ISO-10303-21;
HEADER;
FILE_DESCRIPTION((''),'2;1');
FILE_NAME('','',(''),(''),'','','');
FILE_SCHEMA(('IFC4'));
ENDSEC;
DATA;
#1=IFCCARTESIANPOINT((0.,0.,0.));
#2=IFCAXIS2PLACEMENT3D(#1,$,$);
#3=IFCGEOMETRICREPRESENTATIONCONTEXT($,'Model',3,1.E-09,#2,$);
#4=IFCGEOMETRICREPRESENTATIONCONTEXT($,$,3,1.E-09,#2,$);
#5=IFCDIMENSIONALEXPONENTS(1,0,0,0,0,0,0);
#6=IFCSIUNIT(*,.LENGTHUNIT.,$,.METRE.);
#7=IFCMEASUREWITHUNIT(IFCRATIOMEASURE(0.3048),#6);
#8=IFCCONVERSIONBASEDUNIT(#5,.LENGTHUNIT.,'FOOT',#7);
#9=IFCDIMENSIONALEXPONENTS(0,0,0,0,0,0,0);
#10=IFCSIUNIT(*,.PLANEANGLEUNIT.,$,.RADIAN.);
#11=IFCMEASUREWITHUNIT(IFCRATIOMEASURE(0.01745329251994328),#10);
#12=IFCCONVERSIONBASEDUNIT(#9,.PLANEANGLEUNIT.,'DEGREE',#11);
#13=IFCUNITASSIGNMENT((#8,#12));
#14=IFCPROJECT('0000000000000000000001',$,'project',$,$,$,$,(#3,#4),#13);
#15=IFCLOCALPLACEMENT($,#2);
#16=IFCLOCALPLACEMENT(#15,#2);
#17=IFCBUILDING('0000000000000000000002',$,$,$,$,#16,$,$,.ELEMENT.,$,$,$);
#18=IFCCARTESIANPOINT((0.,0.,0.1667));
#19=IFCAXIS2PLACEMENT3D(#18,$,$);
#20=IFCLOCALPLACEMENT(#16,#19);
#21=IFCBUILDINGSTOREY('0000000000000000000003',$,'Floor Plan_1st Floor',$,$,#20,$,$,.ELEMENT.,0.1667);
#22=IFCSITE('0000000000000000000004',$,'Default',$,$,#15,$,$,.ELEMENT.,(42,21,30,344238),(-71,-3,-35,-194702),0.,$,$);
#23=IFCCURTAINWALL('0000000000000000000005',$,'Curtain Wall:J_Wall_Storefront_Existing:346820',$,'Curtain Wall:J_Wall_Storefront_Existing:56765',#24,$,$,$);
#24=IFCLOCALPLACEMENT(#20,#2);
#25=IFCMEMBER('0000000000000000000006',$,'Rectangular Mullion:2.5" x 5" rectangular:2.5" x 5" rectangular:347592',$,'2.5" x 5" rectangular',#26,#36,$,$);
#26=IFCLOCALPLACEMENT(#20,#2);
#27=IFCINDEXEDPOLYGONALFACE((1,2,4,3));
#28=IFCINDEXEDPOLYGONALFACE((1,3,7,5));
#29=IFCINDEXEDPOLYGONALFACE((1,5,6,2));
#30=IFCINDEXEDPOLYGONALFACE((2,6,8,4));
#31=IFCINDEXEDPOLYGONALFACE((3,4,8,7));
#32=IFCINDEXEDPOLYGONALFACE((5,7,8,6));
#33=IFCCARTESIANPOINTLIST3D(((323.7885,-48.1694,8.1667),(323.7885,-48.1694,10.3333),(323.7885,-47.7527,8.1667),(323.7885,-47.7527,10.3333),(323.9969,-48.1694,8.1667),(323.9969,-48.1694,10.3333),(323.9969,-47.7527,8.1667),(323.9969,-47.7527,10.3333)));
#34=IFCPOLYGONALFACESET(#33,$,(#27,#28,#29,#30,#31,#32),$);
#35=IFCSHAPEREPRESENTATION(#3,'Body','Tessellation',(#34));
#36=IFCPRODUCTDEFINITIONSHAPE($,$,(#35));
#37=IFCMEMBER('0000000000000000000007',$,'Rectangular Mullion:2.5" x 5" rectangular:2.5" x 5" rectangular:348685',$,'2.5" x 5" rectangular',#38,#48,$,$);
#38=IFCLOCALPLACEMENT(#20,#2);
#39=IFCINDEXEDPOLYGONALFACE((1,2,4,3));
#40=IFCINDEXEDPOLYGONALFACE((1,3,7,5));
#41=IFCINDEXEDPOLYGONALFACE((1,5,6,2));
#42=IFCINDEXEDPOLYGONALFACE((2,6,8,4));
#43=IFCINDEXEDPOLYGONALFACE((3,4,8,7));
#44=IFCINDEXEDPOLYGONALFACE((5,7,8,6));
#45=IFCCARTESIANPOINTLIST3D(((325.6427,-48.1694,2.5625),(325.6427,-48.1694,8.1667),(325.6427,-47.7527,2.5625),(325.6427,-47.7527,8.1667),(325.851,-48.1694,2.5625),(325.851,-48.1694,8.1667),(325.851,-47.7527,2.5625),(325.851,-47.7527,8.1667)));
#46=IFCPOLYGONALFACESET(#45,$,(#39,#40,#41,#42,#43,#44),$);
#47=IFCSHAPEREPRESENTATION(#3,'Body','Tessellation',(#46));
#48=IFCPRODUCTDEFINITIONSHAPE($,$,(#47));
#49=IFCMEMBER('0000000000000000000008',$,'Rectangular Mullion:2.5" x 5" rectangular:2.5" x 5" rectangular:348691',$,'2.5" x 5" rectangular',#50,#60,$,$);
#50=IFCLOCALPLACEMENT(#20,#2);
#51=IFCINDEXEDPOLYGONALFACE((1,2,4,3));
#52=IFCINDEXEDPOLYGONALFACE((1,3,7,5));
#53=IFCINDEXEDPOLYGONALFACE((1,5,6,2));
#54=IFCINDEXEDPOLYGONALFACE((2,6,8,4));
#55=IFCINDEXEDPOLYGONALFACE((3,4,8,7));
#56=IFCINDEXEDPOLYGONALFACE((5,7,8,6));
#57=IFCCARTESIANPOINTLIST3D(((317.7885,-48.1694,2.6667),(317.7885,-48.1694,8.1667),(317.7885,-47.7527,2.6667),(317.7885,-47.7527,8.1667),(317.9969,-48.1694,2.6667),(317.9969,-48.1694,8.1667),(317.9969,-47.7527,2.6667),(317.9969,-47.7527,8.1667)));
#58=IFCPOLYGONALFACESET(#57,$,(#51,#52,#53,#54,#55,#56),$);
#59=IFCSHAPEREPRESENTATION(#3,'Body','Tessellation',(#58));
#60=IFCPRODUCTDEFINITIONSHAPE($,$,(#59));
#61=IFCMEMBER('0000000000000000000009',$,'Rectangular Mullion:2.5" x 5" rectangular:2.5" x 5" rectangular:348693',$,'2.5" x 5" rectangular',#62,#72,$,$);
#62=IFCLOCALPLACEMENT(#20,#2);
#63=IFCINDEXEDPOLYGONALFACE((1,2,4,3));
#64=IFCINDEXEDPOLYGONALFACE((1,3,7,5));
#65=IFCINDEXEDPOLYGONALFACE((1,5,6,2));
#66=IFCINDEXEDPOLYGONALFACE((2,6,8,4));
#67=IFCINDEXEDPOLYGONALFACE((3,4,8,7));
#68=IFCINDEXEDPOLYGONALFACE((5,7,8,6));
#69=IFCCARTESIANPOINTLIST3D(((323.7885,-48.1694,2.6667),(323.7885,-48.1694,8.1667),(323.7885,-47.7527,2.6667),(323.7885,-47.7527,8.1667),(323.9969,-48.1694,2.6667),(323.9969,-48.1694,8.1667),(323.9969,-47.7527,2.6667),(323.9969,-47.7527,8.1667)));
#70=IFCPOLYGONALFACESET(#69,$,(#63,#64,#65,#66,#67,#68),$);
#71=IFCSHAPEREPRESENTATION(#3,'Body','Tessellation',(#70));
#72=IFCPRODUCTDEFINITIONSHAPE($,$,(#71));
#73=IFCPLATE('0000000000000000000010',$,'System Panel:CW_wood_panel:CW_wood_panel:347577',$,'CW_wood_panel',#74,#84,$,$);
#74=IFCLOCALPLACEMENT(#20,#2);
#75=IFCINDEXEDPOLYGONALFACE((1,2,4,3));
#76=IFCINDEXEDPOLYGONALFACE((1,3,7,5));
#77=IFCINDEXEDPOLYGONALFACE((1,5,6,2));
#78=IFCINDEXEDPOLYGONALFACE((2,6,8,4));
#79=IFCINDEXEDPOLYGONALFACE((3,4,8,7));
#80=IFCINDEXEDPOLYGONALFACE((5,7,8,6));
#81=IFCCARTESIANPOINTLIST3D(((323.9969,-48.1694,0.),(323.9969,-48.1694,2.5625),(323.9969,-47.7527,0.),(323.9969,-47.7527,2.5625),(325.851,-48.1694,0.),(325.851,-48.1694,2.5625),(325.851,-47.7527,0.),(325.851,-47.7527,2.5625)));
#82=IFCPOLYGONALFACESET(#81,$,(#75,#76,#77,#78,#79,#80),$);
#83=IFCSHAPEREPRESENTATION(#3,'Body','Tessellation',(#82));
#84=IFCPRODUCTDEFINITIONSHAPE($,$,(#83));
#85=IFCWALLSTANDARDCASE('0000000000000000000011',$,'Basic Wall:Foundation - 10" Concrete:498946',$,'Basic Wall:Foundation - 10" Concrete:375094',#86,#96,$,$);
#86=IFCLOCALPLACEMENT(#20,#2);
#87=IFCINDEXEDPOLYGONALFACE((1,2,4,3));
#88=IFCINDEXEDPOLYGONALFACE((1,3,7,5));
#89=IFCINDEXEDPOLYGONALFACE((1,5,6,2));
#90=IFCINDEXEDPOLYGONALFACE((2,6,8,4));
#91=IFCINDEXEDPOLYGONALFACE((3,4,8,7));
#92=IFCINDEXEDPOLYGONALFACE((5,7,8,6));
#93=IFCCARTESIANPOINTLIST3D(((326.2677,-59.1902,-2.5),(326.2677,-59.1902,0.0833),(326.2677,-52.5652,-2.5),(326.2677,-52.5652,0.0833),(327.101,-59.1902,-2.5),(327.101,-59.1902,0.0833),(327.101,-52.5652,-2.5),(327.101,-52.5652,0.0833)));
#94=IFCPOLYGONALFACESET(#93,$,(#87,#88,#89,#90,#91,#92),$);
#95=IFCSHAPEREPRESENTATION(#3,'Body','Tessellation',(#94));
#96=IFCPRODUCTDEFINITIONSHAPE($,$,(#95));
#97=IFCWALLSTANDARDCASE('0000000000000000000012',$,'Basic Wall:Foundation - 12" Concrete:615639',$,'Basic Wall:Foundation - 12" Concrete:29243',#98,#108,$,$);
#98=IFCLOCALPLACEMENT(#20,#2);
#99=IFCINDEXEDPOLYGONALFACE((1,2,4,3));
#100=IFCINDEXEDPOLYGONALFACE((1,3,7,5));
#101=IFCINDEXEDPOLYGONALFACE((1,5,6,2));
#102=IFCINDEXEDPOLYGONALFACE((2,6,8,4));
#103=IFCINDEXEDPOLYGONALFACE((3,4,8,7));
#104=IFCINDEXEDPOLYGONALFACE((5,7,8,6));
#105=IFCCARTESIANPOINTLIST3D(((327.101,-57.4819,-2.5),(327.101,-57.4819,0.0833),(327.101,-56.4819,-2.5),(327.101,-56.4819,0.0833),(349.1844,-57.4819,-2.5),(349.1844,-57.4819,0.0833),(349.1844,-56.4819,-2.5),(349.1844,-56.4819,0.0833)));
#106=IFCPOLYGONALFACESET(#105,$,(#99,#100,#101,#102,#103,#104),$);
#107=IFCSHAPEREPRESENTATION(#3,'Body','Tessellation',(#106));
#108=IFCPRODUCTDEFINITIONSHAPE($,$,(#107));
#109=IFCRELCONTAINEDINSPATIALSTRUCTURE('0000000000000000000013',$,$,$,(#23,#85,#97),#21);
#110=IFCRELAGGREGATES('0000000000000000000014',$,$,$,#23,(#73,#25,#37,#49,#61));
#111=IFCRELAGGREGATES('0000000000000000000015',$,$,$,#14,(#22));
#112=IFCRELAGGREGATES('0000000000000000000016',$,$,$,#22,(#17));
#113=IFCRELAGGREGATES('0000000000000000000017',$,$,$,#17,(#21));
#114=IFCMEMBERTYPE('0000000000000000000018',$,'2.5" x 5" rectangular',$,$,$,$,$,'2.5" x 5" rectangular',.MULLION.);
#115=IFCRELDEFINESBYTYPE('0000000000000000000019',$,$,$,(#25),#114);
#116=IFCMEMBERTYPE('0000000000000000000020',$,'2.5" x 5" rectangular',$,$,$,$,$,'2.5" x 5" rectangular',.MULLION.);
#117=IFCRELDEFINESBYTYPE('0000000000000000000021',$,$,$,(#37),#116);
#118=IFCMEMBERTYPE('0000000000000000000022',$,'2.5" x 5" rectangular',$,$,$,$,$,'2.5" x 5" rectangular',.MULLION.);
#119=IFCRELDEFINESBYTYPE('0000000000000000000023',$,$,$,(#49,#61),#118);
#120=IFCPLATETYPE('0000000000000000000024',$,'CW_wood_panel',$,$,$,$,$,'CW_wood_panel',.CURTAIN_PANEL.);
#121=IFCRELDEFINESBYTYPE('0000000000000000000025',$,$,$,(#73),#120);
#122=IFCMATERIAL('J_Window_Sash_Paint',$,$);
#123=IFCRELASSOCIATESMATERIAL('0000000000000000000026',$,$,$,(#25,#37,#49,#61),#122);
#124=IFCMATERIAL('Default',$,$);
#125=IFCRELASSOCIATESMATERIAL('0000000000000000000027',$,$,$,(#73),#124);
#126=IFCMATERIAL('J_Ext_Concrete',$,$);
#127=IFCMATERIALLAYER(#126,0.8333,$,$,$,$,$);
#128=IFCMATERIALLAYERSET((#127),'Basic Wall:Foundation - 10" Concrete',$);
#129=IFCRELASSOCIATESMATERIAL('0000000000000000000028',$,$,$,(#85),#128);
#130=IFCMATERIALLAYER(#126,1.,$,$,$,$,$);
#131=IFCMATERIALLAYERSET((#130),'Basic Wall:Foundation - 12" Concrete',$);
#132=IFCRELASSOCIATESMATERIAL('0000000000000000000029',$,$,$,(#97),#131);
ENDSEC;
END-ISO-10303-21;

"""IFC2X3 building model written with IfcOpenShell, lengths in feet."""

from ifc_helpers import new_model, entity, si_unit, converted_unit, frame, frame_2d, origin, origin_2d_with_axis, place, context, project, spatial, rectangle, extrude, source, transform, mapped, material, layer, layer_set, layer_usage, type_object, type_shapes, element, aggregate, save


model = new_model("IFC2X3")

# Units and contexts
model_context = context("Model", 3, precision=1e-09, world=origin())
context_of_model = context(None, 3, precision=1e-09, world=origin())
ifc_project = project(units=[converted_unit("LENGTHUNIT", "FOOT", entity("IfcRatioMeasure", 0.3048), si_unit("LENGTHUNIT", "METRE"), dimensions=[1, 0, 0, 0, 0, 0, 0]), converted_unit("PLANEANGLEUNIT", "DEGREE", entity("IfcRatioMeasure", 0.01745329251994328), si_unit("PLANEANGLEUNIT", "RADIAN"), dimensions=[0, 0, 0, 0, 0, 0, 0])], contexts=[model_context, context_of_model])

# Site, building, storey
site_placement = place(None, origin())
site = spatial("IfcSite", under=ifc_project, at=site_placement, Name="Default", CompositionType="ELEMENT", RefLatitude=(42, 21, 30, 344238), RefLongitude=(-71, -3, -35, -194702), RefElevation=0.0)
building_placement = place(site_placement, origin())
building = spatial("IfcBuilding", under=site, at=building_placement, CompositionType="ELEMENT")
storey_placement = place(building_placement, frame((0.0, 0.0, 0.1667)))
storey = spatial("IfcBuildingStorey", under=building, at=storey_placement, Name="Floor Plan_1st Floor", CompositionType="ELEMENT", Elevation=0.1667)

# Curtain wall, members, plate
curtain_wall_placement = place(storey_placement, origin())
curtain_wall = element("IfcCurtainWall", 1, at=curtain_wall_placement, inside=storey, Name="Curtain Wall:J_Wall_Storefront_Existing:346820", ObjectType="Curtain Wall:J_Wall_Storefront_Existing:56765")
ifc_material_1 = material(Name="J_Window_Sash_Paint")
member_type_1 = type_object("IfcMemberType", Name="2.5\" x 5\" rectangular", ElementType="2.5\" x 5\" rectangular", PredefinedType="MULLION")
shared_shape_1 = source(origin(), model_context, "Body", "SweptSolid", [
    extrude(rectangle(XDim=0.2083, YDim=0.4167, at=origin_2d_with_axis()), frame((0.0, 0.0, -2.1667), z_axis=(0.0, 0.0, 1.0), x_axis=(-1.0, 0.0, 0.0)), (0.0, 0.0, 1.0), 2.1667),
])
type_shapes(member_type_1, [shared_shape_1])
member_1_placement = place(storey_placement, frame((323.8927, -47.9611, 8.1667), z_axis=(0.0, 0.0, -1.0), x_axis=(1.0, 0.0, 0.0)))
member_1 = element("IfcMember", 2, at=member_1_placement, type_object=member_type_1, material=ifc_material_1, Name="Rectangular Mullion:2.5\" x 5\" rectangular:2.5\" x 5\" rectangular:347592", ObjectType="2.5\" x 5\" rectangular", context=model_context, shape_type="MappedRepresentation", body=[
    mapped(shared_shape_1, transform((0.0, 0.0, 0.0), scale=1.0)),
])
member_type_2 = type_object("IfcMemberType", Name="2.5\" x 5\" rectangular", ElementType="2.5\" x 5\" rectangular", PredefinedType="MULLION")
shared_shape_2 = source(origin(), model_context, "Body", "SweptSolid", [
    extrude(rectangle(XDim=0.2083, YDim=0.4167, at=origin_2d_with_axis()), frame((-0.1042, 0.0, -5.6042), z_axis=(0.0, 0.0, 1.0), x_axis=(-1.0, 0.0, 0.0)), (0.0, 0.0, 1.0), 5.6042),
])
type_shapes(member_type_2, [shared_shape_2])
member_2_placement = place(storey_placement, frame((325.851, -47.9611, 2.5625), z_axis=(0.0, 0.0, -1.0), x_axis=(1.0, 0.0, 0.0)))
member_2 = element("IfcMember", 3, at=member_2_placement, type_object=member_type_2, material=ifc_material_1, Name="Rectangular Mullion:2.5\" x 5\" rectangular:2.5\" x 5\" rectangular:348685", ObjectType="2.5\" x 5\" rectangular", context=model_context, shape_type="MappedRepresentation", body=[
    mapped(shared_shape_2, transform((0.0, 0.0, 0.0), scale=1.0)),
])
member_type_3 = type_object("IfcMemberType", Name="2.5\" x 5\" rectangular", ElementType="2.5\" x 5\" rectangular", PredefinedType="MULLION")
shared_shape_3 = source(origin(), model_context, "Body", "SweptSolid", [
    extrude(rectangle(XDim=0.2083, YDim=0.4167, at=origin_2d_with_axis()), frame((0.0, 0.0, -5.5), z_axis=(0.0, 0.0, 1.0), x_axis=(-1.0, 0.0, 0.0)), (0.0, 0.0, 1.0), 5.5),
])
type_shapes(member_type_3, [shared_shape_3])
member_3_placement = place(storey_placement, frame((317.8927, -47.9611, 2.6667), z_axis=(0.0, 0.0, -1.0), x_axis=(1.0, 0.0, 0.0)))
member_3 = element("IfcMember", 4, at=member_3_placement, type_object=member_type_3, material=ifc_material_1, Name="Rectangular Mullion:2.5\" x 5\" rectangular:2.5\" x 5\" rectangular:348691", ObjectType="2.5\" x 5\" rectangular", context=model_context, shape_type="MappedRepresentation", body=[
    mapped(shared_shape_3, transform((0.0, 0.0, 0.0), scale=1.0)),
])
member_4_placement = place(storey_placement, frame((323.8927, -47.9611, 2.6667), z_axis=(0.0, 0.0, -1.0), x_axis=(1.0, 0.0, 0.0)))
member_4 = element("IfcMember", 5, at=member_4_placement, type_object=member_type_3, material=ifc_material_1, Name="Rectangular Mullion:2.5\" x 5\" rectangular:2.5\" x 5\" rectangular:348693", ObjectType="2.5\" x 5\" rectangular", context=model_context, shape_type="MappedRepresentation", body=[
    mapped(shared_shape_3, transform((0.0, 0.0, 0.0), scale=1.0)),
])
ifc_material_2 = material(Name="Default")
plate_type_1 = type_object("IfcPlateType", Name="CW_wood_panel", ElementType="CW_wood_panel", PredefinedType="CURTAIN_PANEL")
shared_shape_4 = source(origin(), model_context, "Body", "SweptSolid", [
    extrude(rectangle(XDim=0.4167, YDim=1.8542, at=origin_2d_with_axis()), frame((0.0, 0.0, 0.0), z_axis=(0.0, 0.0, 1.0), x_axis=(0.0, 1.0, 0.0)), (0.0, 0.0, 1.0), 2.5625),
])
type_shapes(plate_type_1, [shared_shape_4])
plate_1_placement = place(storey_placement, frame((324.9239, -47.9611, 0.0)))
plate_1 = element("IfcPlate", 6, at=plate_1_placement, type_object=plate_type_1, material=ifc_material_2, Name="System Panel:CW_wood_panel:CW_wood_panel:347577", ObjectType="CW_wood_panel", context=model_context, shape_type="MappedRepresentation", body=[
    mapped(shared_shape_4, transform((0.0, 0.0, 0.0), scale=1.0)),
])
aggregate(curtain_wall, [plate_1, member_1, member_2, member_3, member_4])

# Walls
ifc_material_3 = material(Name="J_Ext_Concrete")
ifc_layer_1 = layer(ifc_material_3, 0.8333)
ifc_layer_set_1 = layer_set([ifc_layer_1], Name="Basic Wall:Foundation - 10\" Concrete")
ifc_layer_usage_1 = layer_usage(ifc_layer_set_1, "AXIS2", "NEGATIVE", 0.4167)
wall_1_placement = place(storey_placement, frame((326.6844, -52.5652, -2.5), z_axis=(0.0, 0.0, 1.0), x_axis=(0.0, -1.0, 0.0)))
element("IfcWallStandardCase", 7, at=wall_1_placement, inside=storey, material=ifc_layer_usage_1, Name="Basic Wall:Foundation - 10\" Concrete:498946", ObjectType="Basic Wall:Foundation - 10\" Concrete:375094", context=model_context, shape_type="SweptSolid", body=[
    extrude(rectangle(XDim=6.625, YDim=0.8333, at=frame_2d((3.3125, 0.0), x_axis=(-1.0, 0.0))), origin(), (0.0, 0.0, 1.0), 2.5833),
])
ifc_layer_2 = layer(ifc_material_3, 1.0)
ifc_layer_set_2 = layer_set([ifc_layer_2], Name="Basic Wall:Foundation - 12\" Concrete")
ifc_layer_usage_2 = layer_usage(ifc_layer_set_2, "AXIS2", "NEGATIVE", 0.5)
wall_2_placement = place(storey_placement, frame((327.101, -56.9819, -2.5)))
element("IfcWallStandardCase", 8, at=wall_2_placement, inside=storey, material=ifc_layer_usage_2, Name="Basic Wall:Foundation - 12\" Concrete:615639", ObjectType="Basic Wall:Foundation - 12\" Concrete:29243", context=model_context, shape_type="SweptSolid", body=[
    extrude(rectangle(XDim=22.0833, YDim=1.0, at=frame_2d((11.0417, 0.0), x_axis=(-1.0, 0.0))), origin(), (0.0, 0.0, 1.0), 2.5833),
])

save(model, "model.ifc")
